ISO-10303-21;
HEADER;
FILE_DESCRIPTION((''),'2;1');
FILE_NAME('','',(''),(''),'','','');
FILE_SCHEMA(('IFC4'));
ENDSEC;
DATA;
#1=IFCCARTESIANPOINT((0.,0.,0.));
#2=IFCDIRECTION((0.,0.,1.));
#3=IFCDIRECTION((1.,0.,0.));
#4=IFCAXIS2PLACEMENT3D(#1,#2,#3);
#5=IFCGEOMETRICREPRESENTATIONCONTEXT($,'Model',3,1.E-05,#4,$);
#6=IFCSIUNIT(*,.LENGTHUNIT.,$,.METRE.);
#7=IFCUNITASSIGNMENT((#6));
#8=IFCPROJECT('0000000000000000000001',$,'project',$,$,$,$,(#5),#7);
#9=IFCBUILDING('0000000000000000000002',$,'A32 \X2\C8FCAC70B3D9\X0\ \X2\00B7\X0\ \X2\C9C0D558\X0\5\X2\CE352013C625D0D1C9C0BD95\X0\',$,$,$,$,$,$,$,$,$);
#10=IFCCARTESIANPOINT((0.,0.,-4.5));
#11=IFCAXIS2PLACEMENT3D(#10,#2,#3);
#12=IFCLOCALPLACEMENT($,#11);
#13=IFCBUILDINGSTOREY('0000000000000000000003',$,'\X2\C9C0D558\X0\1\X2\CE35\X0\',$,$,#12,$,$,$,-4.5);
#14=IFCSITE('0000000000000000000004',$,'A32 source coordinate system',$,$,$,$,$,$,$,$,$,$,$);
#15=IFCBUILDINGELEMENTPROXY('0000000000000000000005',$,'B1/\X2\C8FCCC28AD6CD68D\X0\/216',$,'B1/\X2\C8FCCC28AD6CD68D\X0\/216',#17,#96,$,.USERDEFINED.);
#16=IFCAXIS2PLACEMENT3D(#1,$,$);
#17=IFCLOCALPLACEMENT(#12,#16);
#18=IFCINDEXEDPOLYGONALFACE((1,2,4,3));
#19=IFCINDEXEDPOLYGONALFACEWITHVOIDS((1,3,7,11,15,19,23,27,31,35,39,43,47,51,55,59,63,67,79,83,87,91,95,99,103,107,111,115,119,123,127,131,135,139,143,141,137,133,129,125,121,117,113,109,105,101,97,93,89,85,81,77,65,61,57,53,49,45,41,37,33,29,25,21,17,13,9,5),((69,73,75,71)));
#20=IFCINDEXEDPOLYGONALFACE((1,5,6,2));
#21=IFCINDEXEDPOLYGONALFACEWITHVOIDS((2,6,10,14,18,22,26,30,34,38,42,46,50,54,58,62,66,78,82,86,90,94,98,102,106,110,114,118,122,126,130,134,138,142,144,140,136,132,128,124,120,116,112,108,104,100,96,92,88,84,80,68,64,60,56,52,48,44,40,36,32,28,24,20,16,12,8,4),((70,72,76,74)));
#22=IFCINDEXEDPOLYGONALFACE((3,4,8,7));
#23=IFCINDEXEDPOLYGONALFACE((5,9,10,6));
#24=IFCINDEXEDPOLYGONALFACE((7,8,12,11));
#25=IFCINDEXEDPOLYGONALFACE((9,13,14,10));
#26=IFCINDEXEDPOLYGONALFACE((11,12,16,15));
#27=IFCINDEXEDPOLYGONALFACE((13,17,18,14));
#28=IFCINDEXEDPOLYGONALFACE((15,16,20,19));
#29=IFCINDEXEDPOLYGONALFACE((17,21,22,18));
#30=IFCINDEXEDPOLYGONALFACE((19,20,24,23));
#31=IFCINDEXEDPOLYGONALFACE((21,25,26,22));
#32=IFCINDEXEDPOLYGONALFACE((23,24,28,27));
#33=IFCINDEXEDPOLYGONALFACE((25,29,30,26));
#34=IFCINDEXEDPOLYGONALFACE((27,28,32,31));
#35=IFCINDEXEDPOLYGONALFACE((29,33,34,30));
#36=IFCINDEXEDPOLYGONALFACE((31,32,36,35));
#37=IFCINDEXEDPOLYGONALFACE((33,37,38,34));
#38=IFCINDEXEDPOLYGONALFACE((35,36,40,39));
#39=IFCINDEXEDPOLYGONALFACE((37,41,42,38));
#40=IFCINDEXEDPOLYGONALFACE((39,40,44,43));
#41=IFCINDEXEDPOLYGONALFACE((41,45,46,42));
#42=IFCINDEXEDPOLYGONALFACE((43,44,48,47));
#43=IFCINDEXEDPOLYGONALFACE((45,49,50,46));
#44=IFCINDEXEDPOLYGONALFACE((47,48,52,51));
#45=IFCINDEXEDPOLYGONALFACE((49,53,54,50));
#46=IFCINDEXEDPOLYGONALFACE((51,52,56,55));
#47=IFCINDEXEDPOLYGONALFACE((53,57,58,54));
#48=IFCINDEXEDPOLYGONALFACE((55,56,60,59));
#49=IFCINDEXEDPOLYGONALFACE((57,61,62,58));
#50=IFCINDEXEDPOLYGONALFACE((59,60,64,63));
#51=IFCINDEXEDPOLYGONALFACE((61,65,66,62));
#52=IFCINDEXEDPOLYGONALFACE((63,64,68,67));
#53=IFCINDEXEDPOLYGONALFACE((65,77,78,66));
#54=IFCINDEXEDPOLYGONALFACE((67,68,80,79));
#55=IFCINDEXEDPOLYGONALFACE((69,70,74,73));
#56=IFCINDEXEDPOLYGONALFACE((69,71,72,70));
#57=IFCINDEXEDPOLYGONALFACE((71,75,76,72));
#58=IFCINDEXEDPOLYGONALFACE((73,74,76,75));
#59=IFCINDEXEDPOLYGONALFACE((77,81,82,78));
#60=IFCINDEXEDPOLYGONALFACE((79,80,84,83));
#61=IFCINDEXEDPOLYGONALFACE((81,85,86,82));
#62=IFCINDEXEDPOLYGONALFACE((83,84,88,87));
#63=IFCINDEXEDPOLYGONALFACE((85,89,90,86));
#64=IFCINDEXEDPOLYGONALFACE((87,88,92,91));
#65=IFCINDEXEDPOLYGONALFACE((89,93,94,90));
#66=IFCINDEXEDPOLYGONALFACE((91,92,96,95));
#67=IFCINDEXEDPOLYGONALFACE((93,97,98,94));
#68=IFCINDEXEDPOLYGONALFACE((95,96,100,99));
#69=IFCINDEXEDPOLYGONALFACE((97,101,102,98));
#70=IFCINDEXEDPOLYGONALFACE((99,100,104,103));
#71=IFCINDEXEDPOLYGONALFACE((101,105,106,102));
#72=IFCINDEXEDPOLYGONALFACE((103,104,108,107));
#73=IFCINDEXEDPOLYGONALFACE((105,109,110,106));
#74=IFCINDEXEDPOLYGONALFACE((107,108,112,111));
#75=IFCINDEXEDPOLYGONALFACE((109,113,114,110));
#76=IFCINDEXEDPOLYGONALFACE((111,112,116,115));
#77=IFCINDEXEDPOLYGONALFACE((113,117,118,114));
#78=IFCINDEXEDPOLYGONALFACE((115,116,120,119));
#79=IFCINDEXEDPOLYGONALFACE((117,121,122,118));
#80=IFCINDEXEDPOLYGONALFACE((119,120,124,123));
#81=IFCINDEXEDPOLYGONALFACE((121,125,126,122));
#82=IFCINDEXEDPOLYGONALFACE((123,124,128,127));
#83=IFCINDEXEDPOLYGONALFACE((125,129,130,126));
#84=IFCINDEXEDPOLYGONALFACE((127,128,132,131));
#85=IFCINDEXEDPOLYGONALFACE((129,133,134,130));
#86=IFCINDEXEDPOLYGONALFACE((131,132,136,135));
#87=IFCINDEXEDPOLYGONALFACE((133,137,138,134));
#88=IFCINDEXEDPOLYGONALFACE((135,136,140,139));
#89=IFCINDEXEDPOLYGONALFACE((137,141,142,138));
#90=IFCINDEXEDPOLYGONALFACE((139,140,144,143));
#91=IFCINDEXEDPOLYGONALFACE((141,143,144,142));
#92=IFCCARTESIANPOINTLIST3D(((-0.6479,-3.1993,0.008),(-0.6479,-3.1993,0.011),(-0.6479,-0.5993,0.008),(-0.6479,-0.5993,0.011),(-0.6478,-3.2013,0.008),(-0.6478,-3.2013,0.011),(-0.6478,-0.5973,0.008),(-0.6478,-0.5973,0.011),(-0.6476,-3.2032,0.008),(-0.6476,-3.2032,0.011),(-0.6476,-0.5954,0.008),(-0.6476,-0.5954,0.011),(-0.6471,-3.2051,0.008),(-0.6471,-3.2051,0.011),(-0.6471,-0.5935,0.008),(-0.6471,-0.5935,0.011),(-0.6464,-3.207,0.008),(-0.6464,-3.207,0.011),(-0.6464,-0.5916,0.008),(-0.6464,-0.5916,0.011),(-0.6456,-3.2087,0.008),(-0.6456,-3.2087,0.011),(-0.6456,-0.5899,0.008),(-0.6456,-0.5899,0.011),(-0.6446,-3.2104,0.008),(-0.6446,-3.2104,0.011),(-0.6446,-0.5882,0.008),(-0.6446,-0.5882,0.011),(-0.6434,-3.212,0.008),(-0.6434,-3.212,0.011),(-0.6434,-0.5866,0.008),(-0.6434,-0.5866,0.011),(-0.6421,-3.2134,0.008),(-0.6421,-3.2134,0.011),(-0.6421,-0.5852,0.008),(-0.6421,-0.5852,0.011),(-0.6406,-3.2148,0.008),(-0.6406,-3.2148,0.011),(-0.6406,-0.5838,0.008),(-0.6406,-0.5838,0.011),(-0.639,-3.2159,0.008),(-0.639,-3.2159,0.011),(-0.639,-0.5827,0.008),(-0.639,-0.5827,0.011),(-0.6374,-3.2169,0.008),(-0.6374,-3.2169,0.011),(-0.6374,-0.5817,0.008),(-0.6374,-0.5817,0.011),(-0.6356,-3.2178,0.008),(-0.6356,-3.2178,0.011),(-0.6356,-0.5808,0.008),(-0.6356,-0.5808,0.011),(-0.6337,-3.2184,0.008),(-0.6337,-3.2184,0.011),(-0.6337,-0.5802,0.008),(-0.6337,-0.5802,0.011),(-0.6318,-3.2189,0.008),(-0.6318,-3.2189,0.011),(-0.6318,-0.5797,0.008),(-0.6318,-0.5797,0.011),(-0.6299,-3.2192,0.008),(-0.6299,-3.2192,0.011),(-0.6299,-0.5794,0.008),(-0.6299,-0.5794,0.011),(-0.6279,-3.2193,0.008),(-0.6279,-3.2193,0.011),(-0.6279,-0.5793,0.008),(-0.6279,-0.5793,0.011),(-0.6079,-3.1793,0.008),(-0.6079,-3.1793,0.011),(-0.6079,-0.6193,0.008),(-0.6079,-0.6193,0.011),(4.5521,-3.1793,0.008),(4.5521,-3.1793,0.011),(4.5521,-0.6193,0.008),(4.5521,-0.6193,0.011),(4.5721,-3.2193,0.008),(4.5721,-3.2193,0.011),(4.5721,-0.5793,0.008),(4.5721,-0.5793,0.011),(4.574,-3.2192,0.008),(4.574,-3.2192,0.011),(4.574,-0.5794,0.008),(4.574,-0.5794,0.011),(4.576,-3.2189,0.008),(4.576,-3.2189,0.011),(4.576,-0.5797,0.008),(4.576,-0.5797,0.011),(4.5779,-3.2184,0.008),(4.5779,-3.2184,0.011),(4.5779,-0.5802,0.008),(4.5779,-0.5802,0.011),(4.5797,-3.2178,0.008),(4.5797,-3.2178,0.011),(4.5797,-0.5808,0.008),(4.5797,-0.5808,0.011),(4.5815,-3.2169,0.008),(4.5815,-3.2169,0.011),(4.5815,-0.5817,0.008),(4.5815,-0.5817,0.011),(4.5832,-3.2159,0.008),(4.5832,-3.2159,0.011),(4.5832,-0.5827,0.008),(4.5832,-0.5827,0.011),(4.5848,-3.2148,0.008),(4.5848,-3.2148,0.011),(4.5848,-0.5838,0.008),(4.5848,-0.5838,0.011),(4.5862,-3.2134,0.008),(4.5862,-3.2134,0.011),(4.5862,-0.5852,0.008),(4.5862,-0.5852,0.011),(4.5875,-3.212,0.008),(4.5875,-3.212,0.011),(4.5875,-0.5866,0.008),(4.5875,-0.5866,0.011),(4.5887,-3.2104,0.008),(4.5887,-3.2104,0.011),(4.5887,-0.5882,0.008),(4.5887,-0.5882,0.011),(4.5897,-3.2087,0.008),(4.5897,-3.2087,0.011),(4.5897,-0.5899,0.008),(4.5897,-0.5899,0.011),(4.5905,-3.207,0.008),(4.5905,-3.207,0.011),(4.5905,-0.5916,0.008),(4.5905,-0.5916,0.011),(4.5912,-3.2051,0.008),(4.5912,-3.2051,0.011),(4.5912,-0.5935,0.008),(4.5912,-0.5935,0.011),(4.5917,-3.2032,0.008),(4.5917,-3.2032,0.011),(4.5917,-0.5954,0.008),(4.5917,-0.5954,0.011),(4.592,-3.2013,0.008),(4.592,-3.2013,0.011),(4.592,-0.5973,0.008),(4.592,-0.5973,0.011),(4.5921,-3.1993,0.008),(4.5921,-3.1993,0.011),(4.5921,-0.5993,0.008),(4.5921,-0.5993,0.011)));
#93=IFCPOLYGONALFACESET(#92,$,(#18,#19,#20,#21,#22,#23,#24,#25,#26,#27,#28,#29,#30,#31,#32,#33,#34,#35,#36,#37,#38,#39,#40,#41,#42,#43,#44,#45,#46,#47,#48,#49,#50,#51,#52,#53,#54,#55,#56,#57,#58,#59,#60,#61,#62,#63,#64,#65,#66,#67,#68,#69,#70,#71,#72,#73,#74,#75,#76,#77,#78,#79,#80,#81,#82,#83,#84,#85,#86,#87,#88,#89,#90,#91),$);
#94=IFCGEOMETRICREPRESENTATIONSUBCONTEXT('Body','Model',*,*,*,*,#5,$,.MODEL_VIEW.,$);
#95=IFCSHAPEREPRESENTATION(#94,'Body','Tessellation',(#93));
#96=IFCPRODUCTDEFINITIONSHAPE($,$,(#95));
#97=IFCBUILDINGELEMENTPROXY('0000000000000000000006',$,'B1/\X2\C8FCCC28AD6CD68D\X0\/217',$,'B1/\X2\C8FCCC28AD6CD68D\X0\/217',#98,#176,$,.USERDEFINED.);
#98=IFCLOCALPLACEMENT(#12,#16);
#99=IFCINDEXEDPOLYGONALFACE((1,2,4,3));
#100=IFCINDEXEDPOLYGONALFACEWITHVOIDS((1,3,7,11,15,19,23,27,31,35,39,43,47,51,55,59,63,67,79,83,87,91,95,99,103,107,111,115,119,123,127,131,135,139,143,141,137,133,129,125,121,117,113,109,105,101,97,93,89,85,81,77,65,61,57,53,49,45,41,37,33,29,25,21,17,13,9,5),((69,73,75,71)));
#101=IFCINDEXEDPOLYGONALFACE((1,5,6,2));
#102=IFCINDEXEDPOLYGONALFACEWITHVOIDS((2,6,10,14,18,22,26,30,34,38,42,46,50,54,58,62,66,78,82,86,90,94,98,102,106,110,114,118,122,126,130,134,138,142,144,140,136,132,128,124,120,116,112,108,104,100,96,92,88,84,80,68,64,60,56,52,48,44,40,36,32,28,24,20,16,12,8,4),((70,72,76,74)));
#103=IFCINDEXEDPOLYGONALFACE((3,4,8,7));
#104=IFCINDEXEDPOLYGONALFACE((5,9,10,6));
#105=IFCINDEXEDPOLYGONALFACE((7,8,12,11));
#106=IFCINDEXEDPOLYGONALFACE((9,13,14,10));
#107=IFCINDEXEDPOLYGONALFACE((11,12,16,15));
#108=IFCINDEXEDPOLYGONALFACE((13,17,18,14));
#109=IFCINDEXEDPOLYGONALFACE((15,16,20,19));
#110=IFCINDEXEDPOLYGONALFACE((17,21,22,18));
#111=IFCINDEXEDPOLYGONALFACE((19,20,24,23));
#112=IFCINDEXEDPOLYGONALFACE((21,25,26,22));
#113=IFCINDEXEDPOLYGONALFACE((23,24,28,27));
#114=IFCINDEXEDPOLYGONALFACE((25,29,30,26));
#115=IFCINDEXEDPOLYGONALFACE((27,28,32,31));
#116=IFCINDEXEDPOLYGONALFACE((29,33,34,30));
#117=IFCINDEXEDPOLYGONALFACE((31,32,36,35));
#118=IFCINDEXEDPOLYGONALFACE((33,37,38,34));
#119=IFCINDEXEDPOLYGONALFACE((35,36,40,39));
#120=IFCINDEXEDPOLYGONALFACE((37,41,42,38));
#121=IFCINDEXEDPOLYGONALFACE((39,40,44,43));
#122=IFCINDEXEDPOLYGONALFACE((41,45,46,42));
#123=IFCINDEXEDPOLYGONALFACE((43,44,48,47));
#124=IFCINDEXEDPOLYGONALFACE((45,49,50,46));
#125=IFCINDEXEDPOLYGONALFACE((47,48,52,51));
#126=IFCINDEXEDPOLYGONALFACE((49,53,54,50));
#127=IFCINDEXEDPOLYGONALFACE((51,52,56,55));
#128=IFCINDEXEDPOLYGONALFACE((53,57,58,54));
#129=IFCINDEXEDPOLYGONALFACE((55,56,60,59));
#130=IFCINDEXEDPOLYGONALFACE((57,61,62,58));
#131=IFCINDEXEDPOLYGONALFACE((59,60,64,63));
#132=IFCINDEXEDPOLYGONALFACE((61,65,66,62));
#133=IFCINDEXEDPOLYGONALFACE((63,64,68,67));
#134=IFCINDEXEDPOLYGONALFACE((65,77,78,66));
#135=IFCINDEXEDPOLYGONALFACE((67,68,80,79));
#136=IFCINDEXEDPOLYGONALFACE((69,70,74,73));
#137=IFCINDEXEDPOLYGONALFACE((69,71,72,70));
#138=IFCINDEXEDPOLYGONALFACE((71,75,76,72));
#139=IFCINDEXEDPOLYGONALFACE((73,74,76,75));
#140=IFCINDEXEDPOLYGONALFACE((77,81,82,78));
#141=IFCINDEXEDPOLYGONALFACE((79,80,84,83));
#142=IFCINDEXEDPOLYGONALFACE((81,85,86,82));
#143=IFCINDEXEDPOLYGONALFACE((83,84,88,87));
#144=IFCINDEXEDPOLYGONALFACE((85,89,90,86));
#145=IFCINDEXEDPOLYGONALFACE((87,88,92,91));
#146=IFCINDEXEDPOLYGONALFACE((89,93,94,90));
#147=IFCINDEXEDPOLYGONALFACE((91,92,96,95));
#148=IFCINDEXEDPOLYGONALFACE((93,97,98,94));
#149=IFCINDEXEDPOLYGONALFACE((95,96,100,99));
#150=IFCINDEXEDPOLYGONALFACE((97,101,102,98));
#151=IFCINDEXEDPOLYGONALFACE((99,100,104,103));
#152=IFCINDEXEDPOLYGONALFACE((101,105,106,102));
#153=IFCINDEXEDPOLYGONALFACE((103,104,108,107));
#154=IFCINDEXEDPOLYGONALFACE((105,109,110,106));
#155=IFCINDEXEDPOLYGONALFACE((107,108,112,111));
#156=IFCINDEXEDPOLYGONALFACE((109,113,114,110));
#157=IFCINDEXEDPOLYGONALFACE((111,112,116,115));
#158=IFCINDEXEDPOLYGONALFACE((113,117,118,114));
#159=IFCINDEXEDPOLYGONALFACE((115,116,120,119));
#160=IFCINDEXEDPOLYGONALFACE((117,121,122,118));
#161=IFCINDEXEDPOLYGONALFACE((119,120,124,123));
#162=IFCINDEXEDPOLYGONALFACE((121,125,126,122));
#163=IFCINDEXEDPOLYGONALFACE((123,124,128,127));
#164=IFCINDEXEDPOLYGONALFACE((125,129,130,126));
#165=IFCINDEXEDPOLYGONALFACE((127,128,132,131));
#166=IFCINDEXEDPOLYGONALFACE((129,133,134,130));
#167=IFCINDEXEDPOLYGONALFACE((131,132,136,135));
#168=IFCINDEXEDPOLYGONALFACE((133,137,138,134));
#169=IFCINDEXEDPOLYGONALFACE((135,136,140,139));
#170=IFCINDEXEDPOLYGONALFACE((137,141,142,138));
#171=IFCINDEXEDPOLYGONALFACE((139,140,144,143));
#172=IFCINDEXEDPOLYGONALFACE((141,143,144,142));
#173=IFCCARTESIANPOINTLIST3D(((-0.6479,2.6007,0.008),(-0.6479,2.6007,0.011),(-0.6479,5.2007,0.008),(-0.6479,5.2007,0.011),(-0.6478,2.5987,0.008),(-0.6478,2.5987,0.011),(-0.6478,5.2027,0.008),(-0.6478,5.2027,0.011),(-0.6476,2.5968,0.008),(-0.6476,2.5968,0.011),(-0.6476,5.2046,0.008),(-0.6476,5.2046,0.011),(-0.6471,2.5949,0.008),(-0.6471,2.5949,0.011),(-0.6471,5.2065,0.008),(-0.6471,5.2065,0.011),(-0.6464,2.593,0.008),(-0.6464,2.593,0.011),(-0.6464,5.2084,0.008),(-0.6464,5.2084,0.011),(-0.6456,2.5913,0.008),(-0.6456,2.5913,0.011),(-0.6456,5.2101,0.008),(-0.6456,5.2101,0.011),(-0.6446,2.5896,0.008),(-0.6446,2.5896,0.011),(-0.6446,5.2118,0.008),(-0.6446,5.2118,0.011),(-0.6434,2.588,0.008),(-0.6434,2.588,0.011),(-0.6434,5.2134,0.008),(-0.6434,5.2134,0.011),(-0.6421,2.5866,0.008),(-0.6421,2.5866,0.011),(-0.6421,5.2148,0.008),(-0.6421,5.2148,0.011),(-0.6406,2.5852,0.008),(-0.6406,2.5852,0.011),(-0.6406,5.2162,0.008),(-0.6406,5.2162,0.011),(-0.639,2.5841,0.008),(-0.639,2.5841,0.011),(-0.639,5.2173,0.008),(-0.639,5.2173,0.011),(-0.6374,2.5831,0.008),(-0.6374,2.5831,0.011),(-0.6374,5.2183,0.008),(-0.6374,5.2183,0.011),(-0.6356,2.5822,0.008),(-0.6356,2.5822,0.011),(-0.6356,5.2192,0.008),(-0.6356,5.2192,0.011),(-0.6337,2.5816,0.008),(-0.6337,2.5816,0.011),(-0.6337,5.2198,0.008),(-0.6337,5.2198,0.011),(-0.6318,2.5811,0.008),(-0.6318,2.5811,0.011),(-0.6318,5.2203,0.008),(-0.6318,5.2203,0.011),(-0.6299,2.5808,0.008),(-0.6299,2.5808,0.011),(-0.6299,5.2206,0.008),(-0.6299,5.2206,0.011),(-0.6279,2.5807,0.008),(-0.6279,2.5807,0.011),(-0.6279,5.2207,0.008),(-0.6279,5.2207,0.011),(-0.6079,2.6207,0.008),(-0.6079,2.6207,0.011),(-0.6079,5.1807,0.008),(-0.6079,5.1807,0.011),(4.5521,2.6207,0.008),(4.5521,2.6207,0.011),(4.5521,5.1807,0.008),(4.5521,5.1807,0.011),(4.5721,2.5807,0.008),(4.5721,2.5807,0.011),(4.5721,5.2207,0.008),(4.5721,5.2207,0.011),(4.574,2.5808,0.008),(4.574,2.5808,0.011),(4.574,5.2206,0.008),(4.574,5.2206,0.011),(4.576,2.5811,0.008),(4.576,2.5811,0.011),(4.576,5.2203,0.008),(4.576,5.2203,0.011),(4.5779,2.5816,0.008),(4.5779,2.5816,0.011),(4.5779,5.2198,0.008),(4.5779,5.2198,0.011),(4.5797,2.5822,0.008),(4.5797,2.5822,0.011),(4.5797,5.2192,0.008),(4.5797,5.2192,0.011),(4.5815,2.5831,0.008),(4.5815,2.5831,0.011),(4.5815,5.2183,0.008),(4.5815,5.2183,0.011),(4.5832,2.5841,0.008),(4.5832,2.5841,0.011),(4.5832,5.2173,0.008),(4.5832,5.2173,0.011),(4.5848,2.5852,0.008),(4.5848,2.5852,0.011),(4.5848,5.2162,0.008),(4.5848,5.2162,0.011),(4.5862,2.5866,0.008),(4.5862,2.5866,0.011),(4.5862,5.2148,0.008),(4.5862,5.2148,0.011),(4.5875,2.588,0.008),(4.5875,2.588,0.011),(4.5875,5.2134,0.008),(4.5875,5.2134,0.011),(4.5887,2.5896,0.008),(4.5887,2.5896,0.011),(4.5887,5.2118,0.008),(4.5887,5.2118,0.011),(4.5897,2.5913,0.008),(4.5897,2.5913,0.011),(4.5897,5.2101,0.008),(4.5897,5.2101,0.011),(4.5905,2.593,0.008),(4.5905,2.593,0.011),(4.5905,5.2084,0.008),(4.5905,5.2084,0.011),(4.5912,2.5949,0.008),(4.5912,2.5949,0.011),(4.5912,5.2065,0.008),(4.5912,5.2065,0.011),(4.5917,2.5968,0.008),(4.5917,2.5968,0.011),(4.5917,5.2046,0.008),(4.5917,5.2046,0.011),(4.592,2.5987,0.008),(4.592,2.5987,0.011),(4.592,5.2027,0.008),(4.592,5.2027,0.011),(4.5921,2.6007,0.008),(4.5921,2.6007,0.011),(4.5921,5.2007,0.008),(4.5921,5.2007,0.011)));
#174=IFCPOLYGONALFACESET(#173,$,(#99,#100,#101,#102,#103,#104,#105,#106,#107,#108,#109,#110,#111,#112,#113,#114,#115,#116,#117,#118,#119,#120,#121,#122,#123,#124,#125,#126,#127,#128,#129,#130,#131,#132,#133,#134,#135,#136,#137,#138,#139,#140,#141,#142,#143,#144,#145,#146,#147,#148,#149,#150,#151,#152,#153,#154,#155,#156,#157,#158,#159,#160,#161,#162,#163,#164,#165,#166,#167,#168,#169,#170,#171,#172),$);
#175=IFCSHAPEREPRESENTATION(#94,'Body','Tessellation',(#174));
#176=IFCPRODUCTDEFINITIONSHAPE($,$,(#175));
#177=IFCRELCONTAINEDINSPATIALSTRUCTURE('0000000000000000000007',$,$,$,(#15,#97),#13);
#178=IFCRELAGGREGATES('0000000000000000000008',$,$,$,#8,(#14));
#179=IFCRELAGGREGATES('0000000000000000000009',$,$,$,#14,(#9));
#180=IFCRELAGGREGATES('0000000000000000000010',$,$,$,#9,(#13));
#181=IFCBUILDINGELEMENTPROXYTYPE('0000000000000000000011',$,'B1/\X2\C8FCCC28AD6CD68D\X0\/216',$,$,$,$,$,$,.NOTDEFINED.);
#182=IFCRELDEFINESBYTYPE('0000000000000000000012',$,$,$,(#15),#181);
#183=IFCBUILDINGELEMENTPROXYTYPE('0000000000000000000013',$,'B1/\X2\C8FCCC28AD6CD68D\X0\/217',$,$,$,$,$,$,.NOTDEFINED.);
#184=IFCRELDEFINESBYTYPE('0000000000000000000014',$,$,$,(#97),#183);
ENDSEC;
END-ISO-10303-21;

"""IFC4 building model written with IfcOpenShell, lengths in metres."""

from ifc_helpers import new_model, si_unit, frame, origin, origin_with_axes, place, context, subcontext, project, spatial, polyline, outline, extrude, source, transform, mapped, type_object, type_shapes, element, save


model = new_model("IFC4")

# Units and contexts
model_context = context("Model", 3, precision=1e-05, world=origin_with_axes())
body_context = subcontext(model_context, "Body", "Model", "MODEL_VIEW")
ifc_project = project(units=[si_unit("LENGTHUNIT", "METRE")], contexts=[model_context])

# Site, building, storey
site = spatial("IfcSite", under=ifc_project, Name="A32 source coordinate system")
building = spatial("IfcBuilding", under=site, Name="A32 주거동 · 지하5층–옥탑지붕")
storey_placement = place(None, frame((0.0, 0.0, -4.5), z_axis=(0.0, 0.0, 1.0), x_axis=(1.0, 0.0, 0.0)))
storey = spatial("IfcBuildingStorey", under=building, at=storey_placement, Name="지하1층", Elevation=-4.5)

# Building element proxies
building_element_proxy_type_1 = type_object("IfcBuildingElementProxyType", Name="B1/주차구획/216", PredefinedType="NOTDEFINED")
shared_shape_1 = source(origin(), body_context, "Body", "SweptSolid", [
    extrude(outline(polyline([(4.5921, -3.1993), (4.592, -3.2013), (4.5917, -3.2032), (4.5912, -3.2051), (4.5905, -3.207), (4.5897, -3.2087), (4.5887, -3.2104), (4.5875, -3.212), (4.5862, -3.2134), (4.5848, -3.2148), (4.5832, -3.2159), (4.5815, -3.2169), (4.5797, -3.2178), (4.5779, -3.2184), (4.576, -3.2189), (4.574, -3.2192), (4.5721, -3.2193), (-0.6279, -3.2193), (-0.6299, -3.2192), (-0.6318, -3.2189), (-0.6337, -3.2184), (-0.6356, -3.2178), (-0.6374, -3.2169), (-0.639, -3.2159), (-0.6406, -3.2148), (-0.6421, -3.2134), (-0.6434, -3.212), (-0.6446, -3.2104), (-0.6456, -3.2087), (-0.6464, -3.207), (-0.6471, -3.2051), (-0.6476, -3.2032), (-0.6478, -3.2013), (-0.6479, -3.1993), (-0.6479, -0.5993), (-0.6478, -0.5973), (-0.6476, -0.5954), (-0.6471, -0.5935), (-0.6464, -0.5916), (-0.6456, -0.5899), (-0.6446, -0.5882), (-0.6434, -0.5866), (-0.6421, -0.5852), (-0.6406, -0.5838), (-0.639, -0.5827), (-0.6374, -0.5817), (-0.6356, -0.5808), (-0.6337, -0.5802), (-0.6318, -0.5797), (-0.6299, -0.5794), (-0.6279, -0.5793), (4.5721, -0.5793), (4.574, -0.5794), (4.576, -0.5797), (4.5779, -0.5802), (4.5797, -0.5808), (4.5815, -0.5817), (4.5832, -0.5827), (4.5848, -0.5838), (4.5862, -0.5852), (4.5875, -0.5866), (4.5887, -0.5882), (4.5897, -0.5899), (4.5905, -0.5916), (4.5912, -0.5935), (4.5917, -0.5954), (4.592, -0.5973), (4.5921, -0.5993), (4.5921, -3.1993)]), holes=[polyline([(4.5521, -3.1793), (4.5521, -0.6193), (-0.6079, -0.6193), (-0.6079, -3.1793), (4.5521, -3.1793)])]), frame((0.0, 0.0, 0.008)), (0.0, 0.0, 1.0), 0.003),
])
type_shapes(building_element_proxy_type_1, [shared_shape_1])
proxy_1_placement = place(storey_placement, origin_with_axes())
element("IfcBuildingElementProxy", 1, at=proxy_1_placement, inside=storey, type_object=building_element_proxy_type_1, Name="B1/주차구획/216", ObjectType="B1/주차구획/216", PredefinedType="USERDEFINED", context=body_context, shape_type="MappedRepresentation", body=[
    mapped(shared_shape_1, transform((0.0, 0.0, 0.0), scale=1.0)),
])
building_element_proxy_type_2 = type_object("IfcBuildingElementProxyType", Name="B1/주차구획/217", PredefinedType="NOTDEFINED")
shared_shape_2 = source(origin(), body_context, "Body", "SweptSolid", [
    extrude(outline(polyline([(-0.6279, 2.5807), (-0.6299, 2.5808), (-0.6318, 2.5811), (-0.6337, 2.5816), (-0.6356, 2.5822), (-0.6374, 2.5831), (-0.639, 2.5841), (-0.6406, 2.5852), (-0.6421, 2.5866), (-0.6434, 2.588), (-0.6446, 2.5896), (-0.6456, 2.5913), (-0.6464, 2.593), (-0.6471, 2.5949), (-0.6476, 2.5968), (-0.6478, 2.5987), (-0.6479, 2.6007), (-0.6479, 5.2007), (-0.6478, 5.2027), (-0.6476, 5.2046), (-0.6471, 5.2065), (-0.6464, 5.2084), (-0.6456, 5.2101), (-0.6446, 5.2118), (-0.6434, 5.2134), (-0.6421, 5.2148), (-0.6406, 5.2162), (-0.639, 5.2173), (-0.6374, 5.2183), (-0.6356, 5.2192), (-0.6337, 5.2198), (-0.6318, 5.2203), (-0.6299, 5.2206), (-0.6279, 5.2207), (4.5721, 5.2207), (4.574, 5.2206), (4.576, 5.2203), (4.5779, 5.2198), (4.5797, 5.2192), (4.5815, 5.2183), (4.5832, 5.2173), (4.5848, 5.2162), (4.5862, 5.2148), (4.5875, 5.2134), (4.5887, 5.2118), (4.5897, 5.2101), (4.5905, 5.2084), (4.5912, 5.2065), (4.5917, 5.2046), (4.592, 5.2027), (4.5921, 5.2007), (4.5921, 2.6007), (4.592, 2.5987), (4.5917, 2.5968), (4.5912, 2.5949), (4.5905, 2.593), (4.5897, 2.5913), (4.5887, 2.5896), (4.5875, 2.588), (4.5862, 2.5866), (4.5848, 2.5852), (4.5832, 2.5841), (4.5815, 2.5831), (4.5797, 2.5822), (4.5779, 2.5816), (4.576, 2.5811), (4.574, 2.5808), (4.5721, 2.5807), (-0.6279, 2.5807)]), holes=[polyline([(-0.6079, 2.6207), (4.5521, 2.6207), (4.5521, 5.1807), (-0.6079, 5.1807), (-0.6079, 2.6207)])]), frame((0.0, 0.0, 0.008)), (0.0, 0.0, 1.0), 0.003),
])
type_shapes(building_element_proxy_type_2, [shared_shape_2])
proxy_2_placement = place(storey_placement, origin_with_axes())
element("IfcBuildingElementProxy", 2, at=proxy_2_placement, inside=storey, type_object=building_element_proxy_type_2, Name="B1/주차구획/217", ObjectType="B1/주차구획/217", PredefinedType="USERDEFINED", context=body_context, shape_type="MappedRepresentation", body=[
    mapped(shared_shape_2, transform((0.0, 0.0, 0.0), scale=1.0)),
])

save(model, "model.ifc")
